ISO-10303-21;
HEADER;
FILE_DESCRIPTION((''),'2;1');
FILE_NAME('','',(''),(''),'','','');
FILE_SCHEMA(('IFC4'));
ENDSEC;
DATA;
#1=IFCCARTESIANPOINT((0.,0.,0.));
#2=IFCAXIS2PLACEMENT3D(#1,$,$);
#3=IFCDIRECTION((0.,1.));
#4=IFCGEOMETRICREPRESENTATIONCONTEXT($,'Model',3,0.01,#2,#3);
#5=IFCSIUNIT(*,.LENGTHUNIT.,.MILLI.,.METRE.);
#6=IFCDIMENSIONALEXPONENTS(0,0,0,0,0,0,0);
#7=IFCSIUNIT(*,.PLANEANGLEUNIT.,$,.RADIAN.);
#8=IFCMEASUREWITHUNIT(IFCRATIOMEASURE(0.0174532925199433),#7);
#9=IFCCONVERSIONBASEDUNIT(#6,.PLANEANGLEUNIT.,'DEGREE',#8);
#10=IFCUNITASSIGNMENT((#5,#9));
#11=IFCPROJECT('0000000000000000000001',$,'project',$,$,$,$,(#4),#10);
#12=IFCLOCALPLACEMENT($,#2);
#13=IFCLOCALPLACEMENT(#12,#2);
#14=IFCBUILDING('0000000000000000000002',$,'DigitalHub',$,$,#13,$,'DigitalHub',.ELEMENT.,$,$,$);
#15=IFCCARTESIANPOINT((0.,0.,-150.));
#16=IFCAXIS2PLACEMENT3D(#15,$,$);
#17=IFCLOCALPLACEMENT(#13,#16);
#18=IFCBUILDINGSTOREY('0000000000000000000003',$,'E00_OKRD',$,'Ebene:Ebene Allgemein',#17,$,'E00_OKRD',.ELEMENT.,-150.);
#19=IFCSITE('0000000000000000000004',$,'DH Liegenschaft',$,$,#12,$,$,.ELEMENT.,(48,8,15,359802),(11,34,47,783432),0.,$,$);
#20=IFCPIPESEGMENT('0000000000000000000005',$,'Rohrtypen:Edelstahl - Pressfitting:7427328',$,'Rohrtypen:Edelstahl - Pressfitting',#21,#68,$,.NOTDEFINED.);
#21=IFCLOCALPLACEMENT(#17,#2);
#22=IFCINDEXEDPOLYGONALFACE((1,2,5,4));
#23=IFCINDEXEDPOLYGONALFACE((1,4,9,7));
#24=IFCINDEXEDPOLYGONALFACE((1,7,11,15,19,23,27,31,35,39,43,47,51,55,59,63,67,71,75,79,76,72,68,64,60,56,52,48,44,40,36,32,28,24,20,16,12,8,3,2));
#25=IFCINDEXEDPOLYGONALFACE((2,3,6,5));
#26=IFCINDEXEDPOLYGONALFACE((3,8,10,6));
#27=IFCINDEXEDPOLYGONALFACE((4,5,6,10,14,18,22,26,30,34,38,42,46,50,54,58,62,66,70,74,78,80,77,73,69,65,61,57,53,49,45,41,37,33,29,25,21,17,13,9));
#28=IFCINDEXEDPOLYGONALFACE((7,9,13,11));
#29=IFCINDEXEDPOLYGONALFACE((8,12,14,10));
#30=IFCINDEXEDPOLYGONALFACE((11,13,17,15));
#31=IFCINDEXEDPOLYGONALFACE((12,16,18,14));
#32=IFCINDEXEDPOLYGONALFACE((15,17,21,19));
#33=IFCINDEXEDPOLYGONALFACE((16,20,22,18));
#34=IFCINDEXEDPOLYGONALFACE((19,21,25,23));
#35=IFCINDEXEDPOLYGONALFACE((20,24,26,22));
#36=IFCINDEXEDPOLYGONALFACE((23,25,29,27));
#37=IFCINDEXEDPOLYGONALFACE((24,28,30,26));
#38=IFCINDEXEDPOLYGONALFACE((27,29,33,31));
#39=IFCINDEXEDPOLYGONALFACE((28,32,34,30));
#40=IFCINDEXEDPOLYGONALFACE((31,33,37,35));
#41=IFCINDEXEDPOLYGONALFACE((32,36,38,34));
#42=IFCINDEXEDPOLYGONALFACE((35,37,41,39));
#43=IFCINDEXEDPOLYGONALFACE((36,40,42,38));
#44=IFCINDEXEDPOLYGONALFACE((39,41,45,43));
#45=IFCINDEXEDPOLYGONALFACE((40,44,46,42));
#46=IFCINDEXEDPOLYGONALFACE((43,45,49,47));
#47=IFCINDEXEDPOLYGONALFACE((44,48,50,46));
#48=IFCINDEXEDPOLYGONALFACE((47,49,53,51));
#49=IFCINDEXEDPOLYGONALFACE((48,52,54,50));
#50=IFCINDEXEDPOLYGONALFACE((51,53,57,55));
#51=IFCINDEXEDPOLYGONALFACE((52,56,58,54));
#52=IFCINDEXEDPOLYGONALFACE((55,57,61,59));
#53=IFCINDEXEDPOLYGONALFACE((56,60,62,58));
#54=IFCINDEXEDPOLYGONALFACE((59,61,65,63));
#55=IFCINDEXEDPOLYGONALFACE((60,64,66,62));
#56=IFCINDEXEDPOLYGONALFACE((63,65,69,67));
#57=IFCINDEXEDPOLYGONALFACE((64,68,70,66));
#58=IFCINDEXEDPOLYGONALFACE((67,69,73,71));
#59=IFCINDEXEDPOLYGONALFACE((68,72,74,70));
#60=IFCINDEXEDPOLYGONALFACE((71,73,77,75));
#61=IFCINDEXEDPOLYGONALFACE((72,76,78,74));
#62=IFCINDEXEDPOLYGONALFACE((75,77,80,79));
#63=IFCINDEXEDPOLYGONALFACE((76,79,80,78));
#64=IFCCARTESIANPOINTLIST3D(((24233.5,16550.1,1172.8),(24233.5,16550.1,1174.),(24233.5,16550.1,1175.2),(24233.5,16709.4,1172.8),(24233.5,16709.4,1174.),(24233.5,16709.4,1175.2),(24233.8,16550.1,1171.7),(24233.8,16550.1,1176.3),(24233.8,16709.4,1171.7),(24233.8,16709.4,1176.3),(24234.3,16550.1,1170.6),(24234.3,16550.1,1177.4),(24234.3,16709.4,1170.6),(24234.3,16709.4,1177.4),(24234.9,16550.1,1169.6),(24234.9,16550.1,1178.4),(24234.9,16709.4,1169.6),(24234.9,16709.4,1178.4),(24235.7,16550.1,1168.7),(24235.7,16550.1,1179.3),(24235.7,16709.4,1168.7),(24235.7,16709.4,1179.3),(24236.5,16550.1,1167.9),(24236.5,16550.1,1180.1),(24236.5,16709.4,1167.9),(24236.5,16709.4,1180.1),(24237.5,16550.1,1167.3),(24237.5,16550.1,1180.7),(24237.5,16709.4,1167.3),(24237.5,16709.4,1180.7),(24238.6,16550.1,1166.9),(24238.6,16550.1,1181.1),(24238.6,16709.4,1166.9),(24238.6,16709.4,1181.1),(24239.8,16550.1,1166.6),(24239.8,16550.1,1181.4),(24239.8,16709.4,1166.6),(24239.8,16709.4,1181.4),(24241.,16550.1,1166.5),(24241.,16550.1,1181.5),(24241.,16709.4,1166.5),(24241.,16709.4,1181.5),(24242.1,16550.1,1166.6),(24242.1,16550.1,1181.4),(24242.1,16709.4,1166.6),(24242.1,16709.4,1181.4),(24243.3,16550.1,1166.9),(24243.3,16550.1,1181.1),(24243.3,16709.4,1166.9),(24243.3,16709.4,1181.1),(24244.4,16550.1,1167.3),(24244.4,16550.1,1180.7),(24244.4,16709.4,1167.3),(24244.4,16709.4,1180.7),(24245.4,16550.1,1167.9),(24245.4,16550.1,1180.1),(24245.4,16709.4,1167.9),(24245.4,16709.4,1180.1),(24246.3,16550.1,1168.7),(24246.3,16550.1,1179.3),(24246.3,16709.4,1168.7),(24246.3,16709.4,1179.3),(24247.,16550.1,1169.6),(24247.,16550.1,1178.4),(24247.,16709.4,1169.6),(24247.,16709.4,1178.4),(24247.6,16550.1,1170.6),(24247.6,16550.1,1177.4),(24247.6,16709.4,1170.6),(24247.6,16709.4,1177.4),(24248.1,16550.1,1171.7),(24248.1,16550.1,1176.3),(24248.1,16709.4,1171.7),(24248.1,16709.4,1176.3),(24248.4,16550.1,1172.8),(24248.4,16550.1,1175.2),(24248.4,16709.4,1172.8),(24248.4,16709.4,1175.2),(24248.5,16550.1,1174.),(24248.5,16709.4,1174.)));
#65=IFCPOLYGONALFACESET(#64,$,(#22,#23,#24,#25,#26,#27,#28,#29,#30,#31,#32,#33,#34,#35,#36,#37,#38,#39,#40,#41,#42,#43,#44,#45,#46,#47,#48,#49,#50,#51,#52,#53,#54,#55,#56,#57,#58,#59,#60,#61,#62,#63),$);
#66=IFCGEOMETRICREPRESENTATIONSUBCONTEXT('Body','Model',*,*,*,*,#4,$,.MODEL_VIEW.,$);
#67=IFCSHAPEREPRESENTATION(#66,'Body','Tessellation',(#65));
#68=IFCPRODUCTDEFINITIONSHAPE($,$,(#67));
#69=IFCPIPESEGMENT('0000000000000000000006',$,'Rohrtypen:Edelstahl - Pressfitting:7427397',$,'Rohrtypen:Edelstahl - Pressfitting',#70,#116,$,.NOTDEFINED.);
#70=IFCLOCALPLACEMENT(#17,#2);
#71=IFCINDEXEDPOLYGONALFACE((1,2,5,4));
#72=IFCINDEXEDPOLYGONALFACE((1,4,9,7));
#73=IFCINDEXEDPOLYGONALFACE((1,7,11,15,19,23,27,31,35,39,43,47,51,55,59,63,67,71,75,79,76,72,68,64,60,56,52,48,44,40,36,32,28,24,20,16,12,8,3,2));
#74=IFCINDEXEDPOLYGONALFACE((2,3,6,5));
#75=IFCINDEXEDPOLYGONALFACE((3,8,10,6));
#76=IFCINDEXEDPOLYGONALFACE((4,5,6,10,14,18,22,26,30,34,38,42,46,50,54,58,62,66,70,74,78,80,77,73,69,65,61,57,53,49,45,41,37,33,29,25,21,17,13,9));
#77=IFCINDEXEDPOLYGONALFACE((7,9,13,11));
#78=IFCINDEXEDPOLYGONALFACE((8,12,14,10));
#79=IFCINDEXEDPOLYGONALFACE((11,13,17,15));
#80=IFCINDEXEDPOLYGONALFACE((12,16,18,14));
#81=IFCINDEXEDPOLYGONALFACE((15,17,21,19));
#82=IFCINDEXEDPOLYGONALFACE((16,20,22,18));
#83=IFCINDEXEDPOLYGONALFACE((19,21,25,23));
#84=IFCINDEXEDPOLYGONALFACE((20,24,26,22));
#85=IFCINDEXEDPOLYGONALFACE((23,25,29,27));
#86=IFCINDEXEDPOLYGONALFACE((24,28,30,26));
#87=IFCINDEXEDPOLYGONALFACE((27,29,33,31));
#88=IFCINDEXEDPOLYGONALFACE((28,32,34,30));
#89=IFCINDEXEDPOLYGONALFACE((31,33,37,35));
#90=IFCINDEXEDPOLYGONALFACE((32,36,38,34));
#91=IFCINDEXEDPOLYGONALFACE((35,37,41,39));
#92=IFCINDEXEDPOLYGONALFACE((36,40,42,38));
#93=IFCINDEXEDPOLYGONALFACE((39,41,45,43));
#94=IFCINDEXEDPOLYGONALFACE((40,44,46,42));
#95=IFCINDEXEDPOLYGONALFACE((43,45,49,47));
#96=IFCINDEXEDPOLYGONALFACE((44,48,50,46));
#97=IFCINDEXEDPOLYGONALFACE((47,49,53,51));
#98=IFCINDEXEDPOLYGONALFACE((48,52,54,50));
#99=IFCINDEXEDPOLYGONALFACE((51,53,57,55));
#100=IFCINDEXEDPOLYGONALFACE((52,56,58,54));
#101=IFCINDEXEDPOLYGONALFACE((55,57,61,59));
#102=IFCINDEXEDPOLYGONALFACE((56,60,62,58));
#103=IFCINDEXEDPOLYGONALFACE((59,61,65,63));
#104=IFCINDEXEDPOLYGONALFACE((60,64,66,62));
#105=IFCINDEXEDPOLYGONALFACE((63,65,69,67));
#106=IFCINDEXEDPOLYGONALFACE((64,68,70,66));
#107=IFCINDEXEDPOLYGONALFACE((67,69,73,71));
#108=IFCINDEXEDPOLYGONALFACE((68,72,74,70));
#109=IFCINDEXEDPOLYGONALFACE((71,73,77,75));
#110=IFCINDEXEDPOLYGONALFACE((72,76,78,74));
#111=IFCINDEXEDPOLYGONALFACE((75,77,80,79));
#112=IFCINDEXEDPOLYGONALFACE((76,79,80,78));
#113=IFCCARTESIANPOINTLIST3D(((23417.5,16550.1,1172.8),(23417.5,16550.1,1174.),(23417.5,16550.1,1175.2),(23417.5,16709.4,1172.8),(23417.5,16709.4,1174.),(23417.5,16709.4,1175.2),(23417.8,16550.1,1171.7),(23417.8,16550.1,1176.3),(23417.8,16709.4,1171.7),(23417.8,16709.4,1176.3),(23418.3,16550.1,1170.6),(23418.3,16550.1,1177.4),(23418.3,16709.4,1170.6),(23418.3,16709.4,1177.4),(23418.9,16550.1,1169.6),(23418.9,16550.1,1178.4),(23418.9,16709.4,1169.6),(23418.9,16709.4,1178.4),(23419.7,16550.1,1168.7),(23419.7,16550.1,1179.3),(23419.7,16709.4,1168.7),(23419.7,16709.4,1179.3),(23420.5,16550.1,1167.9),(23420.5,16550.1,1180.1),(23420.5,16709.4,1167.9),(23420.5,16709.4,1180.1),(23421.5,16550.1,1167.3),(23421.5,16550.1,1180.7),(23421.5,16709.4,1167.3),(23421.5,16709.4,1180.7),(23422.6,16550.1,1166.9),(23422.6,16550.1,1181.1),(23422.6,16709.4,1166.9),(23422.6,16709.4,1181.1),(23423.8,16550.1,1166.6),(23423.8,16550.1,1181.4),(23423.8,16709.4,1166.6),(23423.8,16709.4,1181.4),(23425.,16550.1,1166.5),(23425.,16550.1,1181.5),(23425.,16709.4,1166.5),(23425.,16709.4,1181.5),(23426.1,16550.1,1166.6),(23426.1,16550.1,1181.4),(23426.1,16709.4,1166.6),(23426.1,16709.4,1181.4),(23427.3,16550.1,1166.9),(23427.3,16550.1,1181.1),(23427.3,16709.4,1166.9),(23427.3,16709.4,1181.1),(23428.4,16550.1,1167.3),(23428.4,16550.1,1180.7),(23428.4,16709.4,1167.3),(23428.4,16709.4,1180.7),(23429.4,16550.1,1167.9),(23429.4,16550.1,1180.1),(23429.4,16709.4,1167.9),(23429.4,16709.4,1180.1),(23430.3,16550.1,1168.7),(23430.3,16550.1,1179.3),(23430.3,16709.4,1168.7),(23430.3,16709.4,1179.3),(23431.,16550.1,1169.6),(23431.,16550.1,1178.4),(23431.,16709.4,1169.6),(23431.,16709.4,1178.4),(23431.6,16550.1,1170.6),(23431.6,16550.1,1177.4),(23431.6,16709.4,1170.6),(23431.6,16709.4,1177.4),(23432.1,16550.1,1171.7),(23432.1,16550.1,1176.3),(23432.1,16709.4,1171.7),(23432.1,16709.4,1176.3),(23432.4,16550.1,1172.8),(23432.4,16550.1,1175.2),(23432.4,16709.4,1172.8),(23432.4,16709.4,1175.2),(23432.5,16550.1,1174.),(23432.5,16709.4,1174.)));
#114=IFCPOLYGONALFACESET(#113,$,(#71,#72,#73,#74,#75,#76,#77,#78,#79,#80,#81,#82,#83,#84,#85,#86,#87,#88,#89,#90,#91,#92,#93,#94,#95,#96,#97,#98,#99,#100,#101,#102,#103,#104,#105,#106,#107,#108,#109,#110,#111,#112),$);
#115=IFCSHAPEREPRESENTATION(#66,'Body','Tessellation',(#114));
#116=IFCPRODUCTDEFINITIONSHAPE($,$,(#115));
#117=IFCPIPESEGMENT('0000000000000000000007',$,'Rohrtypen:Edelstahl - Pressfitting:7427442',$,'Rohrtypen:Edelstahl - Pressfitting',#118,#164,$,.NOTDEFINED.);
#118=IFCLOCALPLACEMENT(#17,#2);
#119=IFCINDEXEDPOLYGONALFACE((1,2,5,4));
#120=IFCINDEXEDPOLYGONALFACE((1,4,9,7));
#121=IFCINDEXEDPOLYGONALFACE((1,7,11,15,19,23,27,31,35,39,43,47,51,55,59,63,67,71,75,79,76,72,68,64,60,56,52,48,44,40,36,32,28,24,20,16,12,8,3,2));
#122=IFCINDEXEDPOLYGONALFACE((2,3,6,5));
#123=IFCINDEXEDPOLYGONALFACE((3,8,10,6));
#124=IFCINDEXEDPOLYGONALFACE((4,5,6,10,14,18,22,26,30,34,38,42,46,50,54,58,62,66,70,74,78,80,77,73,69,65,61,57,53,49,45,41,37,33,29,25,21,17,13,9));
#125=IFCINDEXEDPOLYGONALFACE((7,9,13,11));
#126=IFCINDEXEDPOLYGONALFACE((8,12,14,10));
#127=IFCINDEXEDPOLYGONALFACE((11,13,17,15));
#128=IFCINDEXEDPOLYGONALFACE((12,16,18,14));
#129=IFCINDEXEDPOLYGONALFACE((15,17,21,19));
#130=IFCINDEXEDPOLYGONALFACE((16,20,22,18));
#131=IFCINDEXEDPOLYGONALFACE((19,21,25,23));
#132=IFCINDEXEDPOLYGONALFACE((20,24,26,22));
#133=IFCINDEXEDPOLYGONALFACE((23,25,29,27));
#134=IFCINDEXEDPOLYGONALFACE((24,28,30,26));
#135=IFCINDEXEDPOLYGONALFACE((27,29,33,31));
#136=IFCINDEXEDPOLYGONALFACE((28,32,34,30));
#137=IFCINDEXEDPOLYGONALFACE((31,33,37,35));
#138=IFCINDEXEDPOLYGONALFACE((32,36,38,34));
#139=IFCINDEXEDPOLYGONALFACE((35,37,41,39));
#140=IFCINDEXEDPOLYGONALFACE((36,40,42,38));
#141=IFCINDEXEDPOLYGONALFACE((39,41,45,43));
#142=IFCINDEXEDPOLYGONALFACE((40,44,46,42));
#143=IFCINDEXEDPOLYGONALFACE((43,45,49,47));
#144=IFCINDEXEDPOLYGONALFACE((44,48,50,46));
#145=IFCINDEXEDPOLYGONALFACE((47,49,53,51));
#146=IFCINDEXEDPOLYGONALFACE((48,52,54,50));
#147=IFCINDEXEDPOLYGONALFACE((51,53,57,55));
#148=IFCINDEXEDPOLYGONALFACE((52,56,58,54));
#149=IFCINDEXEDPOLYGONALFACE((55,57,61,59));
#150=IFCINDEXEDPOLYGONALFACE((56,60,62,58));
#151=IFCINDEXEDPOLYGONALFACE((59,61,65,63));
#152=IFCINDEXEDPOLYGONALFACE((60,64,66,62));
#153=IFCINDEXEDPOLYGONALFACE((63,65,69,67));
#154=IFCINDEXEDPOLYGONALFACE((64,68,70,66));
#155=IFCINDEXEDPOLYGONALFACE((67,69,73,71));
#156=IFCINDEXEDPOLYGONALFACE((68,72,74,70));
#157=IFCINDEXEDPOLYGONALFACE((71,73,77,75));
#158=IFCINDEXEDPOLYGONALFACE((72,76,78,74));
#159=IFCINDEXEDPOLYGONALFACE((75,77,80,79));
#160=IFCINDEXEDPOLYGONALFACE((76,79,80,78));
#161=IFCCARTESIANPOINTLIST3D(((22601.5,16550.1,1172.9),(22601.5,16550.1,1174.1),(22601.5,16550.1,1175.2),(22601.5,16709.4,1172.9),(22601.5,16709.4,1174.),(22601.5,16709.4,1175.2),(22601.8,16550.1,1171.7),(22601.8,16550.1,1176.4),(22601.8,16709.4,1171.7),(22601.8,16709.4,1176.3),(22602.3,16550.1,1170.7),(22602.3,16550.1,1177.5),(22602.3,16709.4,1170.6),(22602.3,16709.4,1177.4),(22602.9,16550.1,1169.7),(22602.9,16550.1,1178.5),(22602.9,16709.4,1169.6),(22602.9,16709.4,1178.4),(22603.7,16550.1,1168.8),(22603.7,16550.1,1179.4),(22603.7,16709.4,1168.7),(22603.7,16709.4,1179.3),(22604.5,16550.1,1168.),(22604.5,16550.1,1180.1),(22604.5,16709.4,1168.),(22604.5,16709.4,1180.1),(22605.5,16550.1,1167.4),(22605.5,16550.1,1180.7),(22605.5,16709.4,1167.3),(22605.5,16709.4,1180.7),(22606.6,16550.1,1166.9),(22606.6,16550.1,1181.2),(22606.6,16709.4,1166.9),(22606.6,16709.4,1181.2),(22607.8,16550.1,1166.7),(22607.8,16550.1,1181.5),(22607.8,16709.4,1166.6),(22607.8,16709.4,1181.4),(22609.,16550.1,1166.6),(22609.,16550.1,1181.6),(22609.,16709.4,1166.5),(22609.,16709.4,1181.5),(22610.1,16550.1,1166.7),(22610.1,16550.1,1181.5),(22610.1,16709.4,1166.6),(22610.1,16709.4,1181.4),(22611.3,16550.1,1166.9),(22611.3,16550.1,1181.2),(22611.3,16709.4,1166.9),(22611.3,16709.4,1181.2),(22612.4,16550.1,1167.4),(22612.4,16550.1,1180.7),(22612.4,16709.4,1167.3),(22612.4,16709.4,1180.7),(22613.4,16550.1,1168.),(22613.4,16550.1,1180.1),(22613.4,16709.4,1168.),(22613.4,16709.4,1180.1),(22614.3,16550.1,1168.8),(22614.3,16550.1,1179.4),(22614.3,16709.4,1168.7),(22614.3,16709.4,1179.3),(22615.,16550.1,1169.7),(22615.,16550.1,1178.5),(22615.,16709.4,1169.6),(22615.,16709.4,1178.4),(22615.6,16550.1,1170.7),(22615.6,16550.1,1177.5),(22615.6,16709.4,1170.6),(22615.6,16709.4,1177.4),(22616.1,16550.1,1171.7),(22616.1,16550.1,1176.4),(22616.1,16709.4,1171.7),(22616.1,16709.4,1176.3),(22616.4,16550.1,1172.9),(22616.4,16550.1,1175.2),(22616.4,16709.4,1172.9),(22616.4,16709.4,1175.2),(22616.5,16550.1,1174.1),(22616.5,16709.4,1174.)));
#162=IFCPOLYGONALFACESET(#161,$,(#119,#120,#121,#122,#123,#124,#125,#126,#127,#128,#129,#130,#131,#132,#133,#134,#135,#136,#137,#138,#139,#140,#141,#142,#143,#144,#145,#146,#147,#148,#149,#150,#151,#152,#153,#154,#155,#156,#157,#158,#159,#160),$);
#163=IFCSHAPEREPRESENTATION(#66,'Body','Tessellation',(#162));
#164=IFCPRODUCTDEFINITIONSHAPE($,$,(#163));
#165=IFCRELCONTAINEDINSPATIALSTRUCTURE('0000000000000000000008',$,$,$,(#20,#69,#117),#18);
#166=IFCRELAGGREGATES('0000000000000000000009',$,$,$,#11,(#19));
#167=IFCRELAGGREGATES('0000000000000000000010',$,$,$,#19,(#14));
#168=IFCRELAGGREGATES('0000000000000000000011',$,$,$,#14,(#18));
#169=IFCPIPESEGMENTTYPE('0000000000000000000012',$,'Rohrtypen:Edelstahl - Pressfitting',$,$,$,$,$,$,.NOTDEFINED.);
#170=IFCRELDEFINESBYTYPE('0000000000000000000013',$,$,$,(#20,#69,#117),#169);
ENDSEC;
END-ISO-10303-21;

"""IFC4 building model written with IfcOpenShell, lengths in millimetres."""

from ifc_helpers import new_model, entity, si_unit, converted_unit, direction, frame, origin, place, context, subcontext, project, spatial, indexed_curve, outline, extrude, type_object, element, save


model = new_model("IFC4")

# Units and contexts
model_context = context("Model", 3, precision=0.01, world=origin(), true_north=direction((0.0, 1.0)))
body_context = subcontext(model_context, "Body", "Model", "MODEL_VIEW")
ifc_project = project(units=[si_unit("LENGTHUNIT", "METRE", prefix="MILLI"), converted_unit("PLANEANGLEUNIT", "DEGREE", entity("IfcRatioMeasure", 0.0174532925199433), si_unit("PLANEANGLEUNIT", "RADIAN"), dimensions=[0, 0, 0, 0, 0, 0, 0])], contexts=[model_context])

# Site, building, storey
site_placement = place(None, origin())
site = spatial("IfcSite", under=ifc_project, at=site_placement, Name="DH Liegenschaft", CompositionType="ELEMENT", RefLatitude=(48, 8, 15, 359802), RefLongitude=(11, 34, 47, 783432), RefElevation=0.0)
building_placement = place(site_placement, origin())
building = spatial("IfcBuilding", under=site, at=building_placement, Name="DigitalHub", LongName="DigitalHub", CompositionType="ELEMENT")
storey_placement = place(building_placement, frame((0.0, 0.0, -150.0)))
storey = spatial("IfcBuildingStorey", under=building, at=storey_placement, Name="E00_OKRD", ObjectType="Ebene:Ebene Allgemein", LongName="E00_OKRD", CompositionType="ELEMENT", Elevation=-150.0)

# Pipe segments
pipe_segment_type_1 = type_object("IfcPipeSegmentType", Name="Rohrtypen:Edelstahl - Pressfitting", PredefinedType="NOTDEFINED")
pipe_segment_1_placement = place(storey_placement, frame((24231.9, 16550.1, 1164.9)))
element("IfcPipeSegment", 1, at=pipe_segment_1_placement, inside=storey, type_object=pipe_segment_type_1, Name="Rohrtypen:Edelstahl - Pressfitting:7427328", ObjectType="Rohrtypen:Edelstahl - Pressfitting", PredefinedType="NOTDEFINED", context=body_context, shape_type="SweptSolid", body=[
    extrude(outline(indexed_curve([(7.5, 0.0), (7.4, 1.2), (7.1, 2.3), (6.7, 3.4), (6.1, 4.4), (5.3, 5.3), (4.4, 6.1), (3.4, 6.7), (2.3, 7.1), (1.2, 7.4), (0.0, 7.5), (-1.2, 7.4), (-2.3, 7.1), (-3.4, 6.7), (-4.4, 6.1), (-5.3, 5.3), (-6.1, 4.4), (-6.7, 3.4), (-7.1, 2.3), (-7.4, 1.2), (-7.5, 0.0), (-7.4, -1.2), (-7.1, -2.3), (-6.7, -3.4), (-6.1, -4.4), (-5.3, -5.3), (-4.4, -6.1), (-3.4, -6.7), (-2.3, -7.1), (-1.2, -7.4), (0.0, -7.5), (1.2, -7.4), (2.3, -7.1), (3.4, -6.7), (4.4, -6.1), (5.3, -5.3), (6.1, -4.4), (6.7, -3.4), (7.1, -2.3), (7.4, -1.2), (7.5, 0.0)], self_intersect=False)), frame((9.1, 0.0, 9.1), z_axis=(0.0, 1.0, 0.000047), x_axis=(-1.0, 0.0, 0.0)), (0.0, 0.0, 1.0), 159.2),
])
pipe_segment_2_placement = place(storey_placement, frame((23415.9, 16550.1, 1164.9)))
element("IfcPipeSegment", 2, at=pipe_segment_2_placement, inside=storey, type_object=pipe_segment_type_1, Name="Rohrtypen:Edelstahl - Pressfitting:7427397", ObjectType="Rohrtypen:Edelstahl - Pressfitting", PredefinedType="NOTDEFINED", context=body_context, shape_type="SweptSolid", body=[
    extrude(outline(indexed_curve([(7.5, 0.0), (7.4, 1.2), (7.1, 2.3), (6.7, 3.4), (6.1, 4.4), (5.3, 5.3), (4.4, 6.1), (3.4, 6.7), (2.3, 7.1), (1.2, 7.4), (0.0, 7.5), (-1.2, 7.4), (-2.3, 7.1), (-3.4, 6.7), (-4.4, 6.1), (-5.3, 5.3), (-6.1, 4.4), (-6.7, 3.4), (-7.1, 2.3), (-7.4, 1.2), (-7.5, 0.0), (-7.4, -1.2), (-7.1, -2.3), (-6.7, -3.4), (-6.1, -4.4), (-5.3, -5.3), (-4.4, -6.1), (-3.4, -6.7), (-2.3, -7.1), (-1.2, -7.4), (0.0, -7.5), (1.2, -7.4), (2.3, -7.1), (3.4, -6.7), (4.4, -6.1), (5.3, -5.3), (6.1, -4.4), (6.7, -3.4), (7.1, -2.3), (7.4, -1.2), (7.5, 0.0)], self_intersect=False)), frame((9.1, 0.0, 9.1), z_axis=(0.0, 1.0, 0.000054), x_axis=(-1.0, 0.0, 0.0)), (0.0, 0.0, 1.0), 159.2),
])
pipe_segment_3_placement = place(storey_placement, frame((22599.9, 16550.1, 1164.9)))
element("IfcPipeSegment", 3, at=pipe_segment_3_placement, inside=storey, type_object=pipe_segment_type_1, Name="Rohrtypen:Edelstahl - Pressfitting:7427442", ObjectType="Rohrtypen:Edelstahl - Pressfitting", PredefinedType="NOTDEFINED", context=body_context, shape_type="SweptSolid", body=[
    extrude(outline(indexed_curve([(7.5, 0.0), (7.4, 1.2), (7.1, 2.3), (6.7, 3.4), (6.1, 4.4), (5.3, 5.3), (4.4, 6.1), (3.4, 6.7), (2.3, 7.1), (1.2, 7.4), (0.0, 7.5), (-1.2, 7.4), (-2.3, 7.1), (-3.4, 6.7), (-4.4, 6.1), (-5.3, 5.3), (-6.1, 4.4), (-6.7, 3.4), (-7.1, 2.3), (-7.4, 1.2), (-7.5, 0.0), (-7.4, -1.2), (-7.1, -2.3), (-6.7, -3.4), (-6.1, -4.4), (-5.3, -5.3), (-4.4, -6.1), (-3.4, -6.7), (-2.3, -7.1), (-1.2, -7.4), (0.0, -7.5), (1.2, -7.4), (2.3, -7.1), (3.4, -6.7), (4.4, -6.1), (5.3, -5.3), (6.1, -4.4), (6.7, -3.4), (7.1, -2.3), (7.4, -1.2), (7.5, 0.0)], self_intersect=False)), frame((9.1, 0.0, 9.1), z_axis=(0.0, 1.0, -0.0002), x_axis=(-1.0, 0.0, 0.0)), (0.0, 0.0, 1.0), 159.2),
])

save(model, "model.ifc")
